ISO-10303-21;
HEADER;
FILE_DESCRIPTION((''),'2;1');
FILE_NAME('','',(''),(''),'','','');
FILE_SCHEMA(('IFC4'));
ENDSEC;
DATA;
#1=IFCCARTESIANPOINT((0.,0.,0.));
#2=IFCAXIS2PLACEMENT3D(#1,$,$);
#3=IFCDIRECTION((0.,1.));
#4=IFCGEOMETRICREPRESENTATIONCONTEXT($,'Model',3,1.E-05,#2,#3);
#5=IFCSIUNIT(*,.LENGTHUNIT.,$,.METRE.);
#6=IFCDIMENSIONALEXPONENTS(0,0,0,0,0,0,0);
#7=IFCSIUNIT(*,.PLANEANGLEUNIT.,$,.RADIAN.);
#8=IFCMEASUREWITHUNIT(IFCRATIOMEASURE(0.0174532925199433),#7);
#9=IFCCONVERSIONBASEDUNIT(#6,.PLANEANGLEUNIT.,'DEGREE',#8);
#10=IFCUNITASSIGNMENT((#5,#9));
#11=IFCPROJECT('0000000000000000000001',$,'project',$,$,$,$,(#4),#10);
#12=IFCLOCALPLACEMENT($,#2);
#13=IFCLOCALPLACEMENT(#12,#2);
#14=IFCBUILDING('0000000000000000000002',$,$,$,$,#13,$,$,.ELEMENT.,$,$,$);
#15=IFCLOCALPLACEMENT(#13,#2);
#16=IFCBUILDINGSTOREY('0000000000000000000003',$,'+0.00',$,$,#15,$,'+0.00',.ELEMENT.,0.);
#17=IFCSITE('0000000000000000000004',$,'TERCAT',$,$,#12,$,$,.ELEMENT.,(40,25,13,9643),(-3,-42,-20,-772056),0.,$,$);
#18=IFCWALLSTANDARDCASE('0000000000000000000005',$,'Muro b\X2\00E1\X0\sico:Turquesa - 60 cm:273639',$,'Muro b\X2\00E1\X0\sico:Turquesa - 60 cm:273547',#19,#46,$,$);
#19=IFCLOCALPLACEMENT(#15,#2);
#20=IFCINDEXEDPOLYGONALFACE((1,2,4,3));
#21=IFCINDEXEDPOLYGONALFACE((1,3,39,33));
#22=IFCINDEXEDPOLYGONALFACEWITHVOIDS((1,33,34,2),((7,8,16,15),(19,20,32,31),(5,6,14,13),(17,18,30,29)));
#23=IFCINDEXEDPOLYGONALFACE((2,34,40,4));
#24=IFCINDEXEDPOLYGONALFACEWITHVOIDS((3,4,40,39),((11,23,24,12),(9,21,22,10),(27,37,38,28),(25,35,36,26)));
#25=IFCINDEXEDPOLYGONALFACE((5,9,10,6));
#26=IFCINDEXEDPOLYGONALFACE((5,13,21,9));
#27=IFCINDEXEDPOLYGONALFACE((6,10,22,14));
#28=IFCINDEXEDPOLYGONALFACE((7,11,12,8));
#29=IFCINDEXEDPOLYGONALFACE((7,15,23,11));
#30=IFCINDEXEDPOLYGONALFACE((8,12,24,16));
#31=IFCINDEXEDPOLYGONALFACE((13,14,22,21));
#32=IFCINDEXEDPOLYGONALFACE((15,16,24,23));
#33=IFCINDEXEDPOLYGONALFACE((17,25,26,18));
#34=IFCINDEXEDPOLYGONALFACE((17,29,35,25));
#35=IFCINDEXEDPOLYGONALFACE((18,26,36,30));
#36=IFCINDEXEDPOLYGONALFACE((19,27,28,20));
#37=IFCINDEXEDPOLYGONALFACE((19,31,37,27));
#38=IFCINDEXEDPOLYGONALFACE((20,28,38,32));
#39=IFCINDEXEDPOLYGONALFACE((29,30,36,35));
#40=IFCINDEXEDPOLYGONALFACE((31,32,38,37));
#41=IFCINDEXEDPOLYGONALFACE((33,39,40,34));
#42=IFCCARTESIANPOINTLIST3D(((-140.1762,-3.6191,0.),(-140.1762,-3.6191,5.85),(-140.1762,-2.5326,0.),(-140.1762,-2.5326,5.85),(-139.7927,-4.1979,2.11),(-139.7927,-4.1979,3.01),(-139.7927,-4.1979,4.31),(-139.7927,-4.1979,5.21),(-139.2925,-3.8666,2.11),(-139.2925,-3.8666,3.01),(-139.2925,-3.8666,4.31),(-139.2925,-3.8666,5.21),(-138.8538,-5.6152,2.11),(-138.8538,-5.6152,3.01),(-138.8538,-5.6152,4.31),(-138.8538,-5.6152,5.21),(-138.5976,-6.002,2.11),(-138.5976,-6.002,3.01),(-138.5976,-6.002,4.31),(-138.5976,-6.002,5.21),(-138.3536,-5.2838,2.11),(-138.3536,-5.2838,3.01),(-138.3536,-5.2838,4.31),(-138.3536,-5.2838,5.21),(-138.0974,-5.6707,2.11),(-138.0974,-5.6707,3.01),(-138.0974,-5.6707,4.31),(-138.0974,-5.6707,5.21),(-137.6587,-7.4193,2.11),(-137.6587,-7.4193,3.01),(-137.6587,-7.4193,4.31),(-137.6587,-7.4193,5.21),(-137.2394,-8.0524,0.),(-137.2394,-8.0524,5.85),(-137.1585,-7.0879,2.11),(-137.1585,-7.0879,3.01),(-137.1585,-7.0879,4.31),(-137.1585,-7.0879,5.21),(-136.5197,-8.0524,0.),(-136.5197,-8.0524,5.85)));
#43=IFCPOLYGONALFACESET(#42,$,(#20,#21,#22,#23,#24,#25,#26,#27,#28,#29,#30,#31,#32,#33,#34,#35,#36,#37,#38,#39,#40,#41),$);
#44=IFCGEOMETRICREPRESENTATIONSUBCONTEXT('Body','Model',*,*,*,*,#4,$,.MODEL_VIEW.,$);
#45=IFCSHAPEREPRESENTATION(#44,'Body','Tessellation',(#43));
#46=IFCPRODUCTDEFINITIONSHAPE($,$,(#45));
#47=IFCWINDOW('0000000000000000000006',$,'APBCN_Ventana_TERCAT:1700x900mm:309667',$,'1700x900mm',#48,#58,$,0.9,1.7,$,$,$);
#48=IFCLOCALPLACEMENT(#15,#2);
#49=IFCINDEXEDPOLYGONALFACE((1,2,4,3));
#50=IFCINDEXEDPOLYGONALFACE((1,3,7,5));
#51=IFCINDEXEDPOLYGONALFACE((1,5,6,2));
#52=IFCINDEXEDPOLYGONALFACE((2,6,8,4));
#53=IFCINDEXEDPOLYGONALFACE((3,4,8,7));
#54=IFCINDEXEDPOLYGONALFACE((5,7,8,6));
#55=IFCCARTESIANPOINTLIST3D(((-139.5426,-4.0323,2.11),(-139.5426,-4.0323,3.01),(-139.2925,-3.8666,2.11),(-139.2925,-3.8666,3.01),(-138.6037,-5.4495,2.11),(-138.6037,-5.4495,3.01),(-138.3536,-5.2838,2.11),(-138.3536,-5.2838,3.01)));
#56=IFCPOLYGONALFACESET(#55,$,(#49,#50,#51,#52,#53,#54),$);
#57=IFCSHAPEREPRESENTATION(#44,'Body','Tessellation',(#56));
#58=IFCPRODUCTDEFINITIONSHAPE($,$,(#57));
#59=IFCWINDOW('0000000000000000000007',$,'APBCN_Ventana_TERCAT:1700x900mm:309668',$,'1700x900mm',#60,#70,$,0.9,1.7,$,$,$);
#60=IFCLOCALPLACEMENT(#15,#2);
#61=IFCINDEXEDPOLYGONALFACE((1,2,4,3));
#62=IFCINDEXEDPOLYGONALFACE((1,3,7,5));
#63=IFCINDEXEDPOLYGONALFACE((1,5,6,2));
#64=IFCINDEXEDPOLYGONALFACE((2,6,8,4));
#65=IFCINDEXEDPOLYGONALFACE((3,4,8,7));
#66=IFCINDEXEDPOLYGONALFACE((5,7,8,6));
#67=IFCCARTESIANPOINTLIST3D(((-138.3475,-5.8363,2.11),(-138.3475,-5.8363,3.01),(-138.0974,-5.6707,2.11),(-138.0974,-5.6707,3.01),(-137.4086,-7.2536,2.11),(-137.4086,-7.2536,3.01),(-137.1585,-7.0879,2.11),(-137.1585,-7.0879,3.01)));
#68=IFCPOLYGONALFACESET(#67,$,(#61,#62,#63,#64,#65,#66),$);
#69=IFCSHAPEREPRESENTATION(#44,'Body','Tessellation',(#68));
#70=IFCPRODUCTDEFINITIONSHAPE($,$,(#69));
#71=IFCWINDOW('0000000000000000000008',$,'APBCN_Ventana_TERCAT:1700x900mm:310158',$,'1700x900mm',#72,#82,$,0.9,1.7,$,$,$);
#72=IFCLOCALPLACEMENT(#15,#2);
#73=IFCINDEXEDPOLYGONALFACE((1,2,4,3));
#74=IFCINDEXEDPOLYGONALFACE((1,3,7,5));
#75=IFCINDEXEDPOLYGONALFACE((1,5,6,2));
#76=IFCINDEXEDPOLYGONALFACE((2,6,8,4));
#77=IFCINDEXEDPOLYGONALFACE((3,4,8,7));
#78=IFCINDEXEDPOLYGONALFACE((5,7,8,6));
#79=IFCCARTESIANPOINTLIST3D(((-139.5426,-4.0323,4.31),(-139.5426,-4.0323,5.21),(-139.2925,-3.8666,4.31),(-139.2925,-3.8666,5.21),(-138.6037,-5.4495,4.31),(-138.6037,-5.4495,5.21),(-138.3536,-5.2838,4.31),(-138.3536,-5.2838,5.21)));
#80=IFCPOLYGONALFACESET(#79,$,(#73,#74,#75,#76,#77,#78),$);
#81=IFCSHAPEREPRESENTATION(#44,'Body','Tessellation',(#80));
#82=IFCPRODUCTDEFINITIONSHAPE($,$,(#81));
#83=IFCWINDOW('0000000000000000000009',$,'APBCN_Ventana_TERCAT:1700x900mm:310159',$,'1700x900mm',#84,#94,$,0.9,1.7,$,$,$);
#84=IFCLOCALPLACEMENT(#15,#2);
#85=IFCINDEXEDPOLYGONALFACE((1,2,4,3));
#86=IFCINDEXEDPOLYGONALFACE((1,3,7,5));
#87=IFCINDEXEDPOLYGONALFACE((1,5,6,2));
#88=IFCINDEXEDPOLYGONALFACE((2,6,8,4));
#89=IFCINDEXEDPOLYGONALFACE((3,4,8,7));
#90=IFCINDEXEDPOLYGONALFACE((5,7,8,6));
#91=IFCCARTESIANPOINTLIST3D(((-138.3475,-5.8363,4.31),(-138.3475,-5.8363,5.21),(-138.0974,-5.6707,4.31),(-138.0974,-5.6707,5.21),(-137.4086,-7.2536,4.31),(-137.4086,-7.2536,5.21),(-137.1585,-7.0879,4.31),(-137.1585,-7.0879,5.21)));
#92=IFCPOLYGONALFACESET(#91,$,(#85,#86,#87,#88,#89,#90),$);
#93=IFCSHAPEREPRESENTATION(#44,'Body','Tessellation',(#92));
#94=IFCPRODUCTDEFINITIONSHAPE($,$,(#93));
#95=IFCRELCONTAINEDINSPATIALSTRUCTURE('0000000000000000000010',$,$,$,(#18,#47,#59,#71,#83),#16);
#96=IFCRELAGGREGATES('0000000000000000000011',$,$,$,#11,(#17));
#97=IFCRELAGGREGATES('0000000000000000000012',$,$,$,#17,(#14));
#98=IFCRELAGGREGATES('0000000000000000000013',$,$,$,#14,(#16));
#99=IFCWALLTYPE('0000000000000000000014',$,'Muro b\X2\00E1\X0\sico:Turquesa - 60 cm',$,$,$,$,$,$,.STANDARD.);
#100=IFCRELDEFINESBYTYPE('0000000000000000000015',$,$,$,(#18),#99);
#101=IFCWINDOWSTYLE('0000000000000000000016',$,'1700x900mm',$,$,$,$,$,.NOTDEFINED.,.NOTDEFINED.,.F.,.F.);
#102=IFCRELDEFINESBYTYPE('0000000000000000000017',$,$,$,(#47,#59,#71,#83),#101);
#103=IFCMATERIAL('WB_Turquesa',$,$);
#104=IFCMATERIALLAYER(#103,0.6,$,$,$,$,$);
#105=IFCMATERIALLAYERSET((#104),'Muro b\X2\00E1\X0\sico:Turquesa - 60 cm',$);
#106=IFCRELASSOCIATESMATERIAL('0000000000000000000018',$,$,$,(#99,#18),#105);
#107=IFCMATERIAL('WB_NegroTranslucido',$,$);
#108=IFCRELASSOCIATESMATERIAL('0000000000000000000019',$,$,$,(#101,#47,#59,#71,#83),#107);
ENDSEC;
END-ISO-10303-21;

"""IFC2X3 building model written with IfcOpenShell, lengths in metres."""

from ifc_helpers import new_model, entity, si_unit, converted_unit, direction, frame, frame_2d, origin, origin_2d_with_axis, place, context, subcontext, project, spatial, polyline, rectangle, outline, extrude, clip, bounded_halfspace, source, transform, mapped, material, layer, layer_set, layer_usage, type_object, type_shapes, element, fill, save


model = new_model("IFC2X3")

# Units and contexts
model_context = context("Model", 3, precision=1e-05, world=origin(), true_north=direction((0.0, 1.0)))
body_context = subcontext(model_context, "Body", "Model", "MODEL_VIEW")
ifc_project = project(units=[si_unit("LENGTHUNIT", "METRE"), converted_unit("PLANEANGLEUNIT", "DEGREE", entity("IfcRatioMeasure", 0.0174532925199433), si_unit("PLANEANGLEUNIT", "RADIAN"), dimensions=[0, 0, 0, 0, 0, 0, 0])], contexts=[model_context])

# Site, building, storey
site_placement = place(None, origin())
site = spatial("IfcSite", under=ifc_project, at=site_placement, Name="TERCAT", CompositionType="ELEMENT", RefLatitude=(40, 25, 13, 9643), RefLongitude=(-3, -42, -20, -772056), RefElevation=0.0)
building_placement = place(site_placement, origin())
building = spatial("IfcBuilding", under=site, at=building_placement, CompositionType="ELEMENT")
storey_placement = place(building_placement, origin())
storey = spatial("IfcBuildingStorey", under=building, at=storey_placement, Name="+0.00", LongName="+0.00", CompositionType="ELEMENT", Elevation=0.0)

# Wall, openings, windows
ifc_material_1 = material(Name="WB_Turquesa")
ifc_layer_1 = layer(ifc_material_1, 0.6)
ifc_layer_set_1 = layer_set([ifc_layer_1], Name="Muro básico:Turquesa - 60 cm")
ifc_layer_usage_1 = layer_usage(ifc_layer_set_1, "AXIS2", "POSITIVE", -0.3)
wall_type_1 = type_object("IfcWallType", Name="Muro básico:Turquesa - 60 cm", PredefinedType="STANDARD", material=ifc_layer_set_1)
wall_1_placement = place(storey_placement, frame((-140.4263, -2.6983, 0.0), z_axis=(0.0, 0.0, 1.0), x_axis=(0.552261, -0.833671, 0.0)))
wall_1 = element("IfcWallStandardCase", 1, at=wall_1_placement, inside=storey, type_object=wall_type_1, material=ifc_layer_usage_1, Name="Muro básico:Turquesa - 60 cm:273639", ObjectType="Muro básico:Turquesa - 60 cm:273547", context=body_context, shape_type="Clipping", body=[
    clip(extrude(outline(polyline([(6.2235, -0.3), (6.621, 0.3), (0.0, 0.3), (0.9057, -0.3), (6.2235, -0.3)])), origin(), (0.0, 0.0, 1.0), 5.85), bounded_halfspace(frame((0.9057, -0.3, 5.85), z_axis=(0.0, 0.0, 1.0), x_axis=(0.552261, 0.833671, 0.0)), False, frame((0.9057, -0.3, 5.85), z_axis=(0.0, 0.0, 1.0), x_axis=(0.552261, 0.833671, 0.0)), polyline([(0.0, 0.0), (2.9368, -4.4333), (3.6565, -4.4333), (0.0, 1.0864), (0.0, 0.0)]))),
])
opening_1_placement = place(wall_1_placement, frame((5.4641, 0.3, 2.11)))
opening_1 = element("IfcOpeningElement", 2, at=opening_1_placement, cuts=wall_1, ObjectType="Opening", context=body_context, shape_type="SweptSolid", body=[
    extrude(rectangle(XDim=0.9, YDim=1.7, at=frame_2d((0.45, 0.85), x_axis=(1.0, 0.0))), frame((0.0, 0.0, 0.0), z_axis=(0.0, -1.0, 0.0), x_axis=(0.0, 0.0, 1.0)), (0.0, 0.0, 1.0), 0.6),
])
opening_2_placement = place(wall_1_placement, frame((3.3001, 0.3, 2.11)))
opening_2 = element("IfcOpeningElement", 3, at=opening_2_placement, cuts=wall_1, ObjectType="Opening", context=body_context, shape_type="SweptSolid", body=[
    extrude(rectangle(XDim=0.9, YDim=1.7, at=frame_2d((0.45, 0.85), x_axis=(1.0, 0.0))), frame((0.0, 0.0, 0.0), z_axis=(0.0, -1.0, 0.0), x_axis=(0.0, 0.0, 1.0)), (0.0, 0.0, 1.0), 0.6),
])
opening_3_placement = place(wall_1_placement, frame((3.3001, 0.3, 4.31)))
opening_3 = element("IfcOpeningElement", 4, at=opening_3_placement, cuts=wall_1, ObjectType="Opening", context=body_context, shape_type="SweptSolid", body=[
    extrude(rectangle(XDim=0.9, YDim=1.7, at=frame_2d((0.45, 0.85), x_axis=(1.0, 0.0))), frame((0.0, 0.0, 0.0), z_axis=(0.0, -1.0, 0.0), x_axis=(0.0, 0.0, 1.0)), (0.0, 0.0, 1.0), 0.6),
])
opening_4_placement = place(wall_1_placement, frame((5.4641, 0.3, 4.31)))
opening_4 = element("IfcOpeningElement", 5, at=opening_4_placement, cuts=wall_1, ObjectType="Opening", context=body_context, shape_type="SweptSolid", body=[
    extrude(rectangle(XDim=0.9, YDim=1.7, at=frame_2d((0.45, 0.85), x_axis=(1.0, 0.0))), frame((0.0, 0.0, 0.0), z_axis=(0.0, -1.0, 0.0), x_axis=(0.0, 0.0, 1.0)), (0.0, 0.0, 1.0), 0.6),
])
ifc_material_2 = material(Name="WB_NegroTranslucido")
window_style = type_object("IfcWindowStyle", Name="1700x900mm", ConstructionType="NOTDEFINED", OperationType="NOTDEFINED", ParameterTakesPrecedence=False, Sizeable=False, material=ifc_material_2)
shared_shape = source(origin(), body_context, "Body", "SweptSolid", [
    extrude(rectangle(XDim=1.7, YDim=0.3, at=origin_2d_with_axis()), frame((0.85, 0.15, 0.0)), (0.0, 0.0, 1.0), 0.9),
])
type_shapes(window_style, [shared_shape])
window_1_placement = place(opening_2_placement, frame((0.0, 0.0, 0.0), z_axis=(0.0, 0.0, 1.0), x_axis=(-1.0, 0.0, 0.0)))
window_1 = element("IfcWindow", 6, at=window_1_placement, inside=storey, type_object=window_style, material=ifc_material_2, Name="APBCN_Ventana_TERCAT:1700x900mm:309667", ObjectType="1700x900mm", OverallHeight=0.9, OverallWidth=1.7, context=body_context, shape_type="MappedRepresentation", body=[
    mapped(shared_shape, transform((0.0, 0.0, 0.0), scale=1.0)),
])
fill(opening_2, window_1)
window_2_placement = place(opening_1_placement, frame((0.0, 0.0, 0.0), z_axis=(0.0, 0.0, 1.0), x_axis=(-1.0, 0.0, 0.0)))
window_2 = element("IfcWindow", 7, at=window_2_placement, inside=storey, type_object=window_style, material=ifc_material_2, Name="APBCN_Ventana_TERCAT:1700x900mm:309668", ObjectType="1700x900mm", OverallHeight=0.9, OverallWidth=1.7, context=body_context, shape_type="MappedRepresentation", body=[
    mapped(shared_shape, transform((0.0, 0.0, 0.0), scale=1.0)),
])
fill(opening_1, window_2)
window_3_placement = place(opening_3_placement, frame((0.0, 0.0, 0.0), z_axis=(0.0, 0.0, 1.0), x_axis=(-1.0, 0.0, 0.0)))
window_3 = element("IfcWindow", 8, at=window_3_placement, inside=storey, type_object=window_style, material=ifc_material_2, Name="APBCN_Ventana_TERCAT:1700x900mm:310158", ObjectType="1700x900mm", OverallHeight=0.9, OverallWidth=1.7, context=body_context, shape_type="MappedRepresentation", body=[
    mapped(shared_shape, transform((0.0, 0.0, 0.0), scale=1.0)),
])
fill(opening_3, window_3)
window_4_placement = place(opening_4_placement, frame((0.0, 0.0, 0.0), z_axis=(0.0, 0.0, 1.0), x_axis=(-1.0, 0.0, 0.0)))
window_4 = element("IfcWindow", 9, at=window_4_placement, inside=storey, type_object=window_style, material=ifc_material_2, Name="APBCN_Ventana_TERCAT:1700x900mm:310159", ObjectType="1700x900mm", OverallHeight=0.9, OverallWidth=1.7, context=body_context, shape_type="MappedRepresentation", body=[
    mapped(shared_shape, transform((0.0, 0.0, 0.0), scale=1.0)),
])
fill(opening_4, window_4)

save(model, "model.ifc")
